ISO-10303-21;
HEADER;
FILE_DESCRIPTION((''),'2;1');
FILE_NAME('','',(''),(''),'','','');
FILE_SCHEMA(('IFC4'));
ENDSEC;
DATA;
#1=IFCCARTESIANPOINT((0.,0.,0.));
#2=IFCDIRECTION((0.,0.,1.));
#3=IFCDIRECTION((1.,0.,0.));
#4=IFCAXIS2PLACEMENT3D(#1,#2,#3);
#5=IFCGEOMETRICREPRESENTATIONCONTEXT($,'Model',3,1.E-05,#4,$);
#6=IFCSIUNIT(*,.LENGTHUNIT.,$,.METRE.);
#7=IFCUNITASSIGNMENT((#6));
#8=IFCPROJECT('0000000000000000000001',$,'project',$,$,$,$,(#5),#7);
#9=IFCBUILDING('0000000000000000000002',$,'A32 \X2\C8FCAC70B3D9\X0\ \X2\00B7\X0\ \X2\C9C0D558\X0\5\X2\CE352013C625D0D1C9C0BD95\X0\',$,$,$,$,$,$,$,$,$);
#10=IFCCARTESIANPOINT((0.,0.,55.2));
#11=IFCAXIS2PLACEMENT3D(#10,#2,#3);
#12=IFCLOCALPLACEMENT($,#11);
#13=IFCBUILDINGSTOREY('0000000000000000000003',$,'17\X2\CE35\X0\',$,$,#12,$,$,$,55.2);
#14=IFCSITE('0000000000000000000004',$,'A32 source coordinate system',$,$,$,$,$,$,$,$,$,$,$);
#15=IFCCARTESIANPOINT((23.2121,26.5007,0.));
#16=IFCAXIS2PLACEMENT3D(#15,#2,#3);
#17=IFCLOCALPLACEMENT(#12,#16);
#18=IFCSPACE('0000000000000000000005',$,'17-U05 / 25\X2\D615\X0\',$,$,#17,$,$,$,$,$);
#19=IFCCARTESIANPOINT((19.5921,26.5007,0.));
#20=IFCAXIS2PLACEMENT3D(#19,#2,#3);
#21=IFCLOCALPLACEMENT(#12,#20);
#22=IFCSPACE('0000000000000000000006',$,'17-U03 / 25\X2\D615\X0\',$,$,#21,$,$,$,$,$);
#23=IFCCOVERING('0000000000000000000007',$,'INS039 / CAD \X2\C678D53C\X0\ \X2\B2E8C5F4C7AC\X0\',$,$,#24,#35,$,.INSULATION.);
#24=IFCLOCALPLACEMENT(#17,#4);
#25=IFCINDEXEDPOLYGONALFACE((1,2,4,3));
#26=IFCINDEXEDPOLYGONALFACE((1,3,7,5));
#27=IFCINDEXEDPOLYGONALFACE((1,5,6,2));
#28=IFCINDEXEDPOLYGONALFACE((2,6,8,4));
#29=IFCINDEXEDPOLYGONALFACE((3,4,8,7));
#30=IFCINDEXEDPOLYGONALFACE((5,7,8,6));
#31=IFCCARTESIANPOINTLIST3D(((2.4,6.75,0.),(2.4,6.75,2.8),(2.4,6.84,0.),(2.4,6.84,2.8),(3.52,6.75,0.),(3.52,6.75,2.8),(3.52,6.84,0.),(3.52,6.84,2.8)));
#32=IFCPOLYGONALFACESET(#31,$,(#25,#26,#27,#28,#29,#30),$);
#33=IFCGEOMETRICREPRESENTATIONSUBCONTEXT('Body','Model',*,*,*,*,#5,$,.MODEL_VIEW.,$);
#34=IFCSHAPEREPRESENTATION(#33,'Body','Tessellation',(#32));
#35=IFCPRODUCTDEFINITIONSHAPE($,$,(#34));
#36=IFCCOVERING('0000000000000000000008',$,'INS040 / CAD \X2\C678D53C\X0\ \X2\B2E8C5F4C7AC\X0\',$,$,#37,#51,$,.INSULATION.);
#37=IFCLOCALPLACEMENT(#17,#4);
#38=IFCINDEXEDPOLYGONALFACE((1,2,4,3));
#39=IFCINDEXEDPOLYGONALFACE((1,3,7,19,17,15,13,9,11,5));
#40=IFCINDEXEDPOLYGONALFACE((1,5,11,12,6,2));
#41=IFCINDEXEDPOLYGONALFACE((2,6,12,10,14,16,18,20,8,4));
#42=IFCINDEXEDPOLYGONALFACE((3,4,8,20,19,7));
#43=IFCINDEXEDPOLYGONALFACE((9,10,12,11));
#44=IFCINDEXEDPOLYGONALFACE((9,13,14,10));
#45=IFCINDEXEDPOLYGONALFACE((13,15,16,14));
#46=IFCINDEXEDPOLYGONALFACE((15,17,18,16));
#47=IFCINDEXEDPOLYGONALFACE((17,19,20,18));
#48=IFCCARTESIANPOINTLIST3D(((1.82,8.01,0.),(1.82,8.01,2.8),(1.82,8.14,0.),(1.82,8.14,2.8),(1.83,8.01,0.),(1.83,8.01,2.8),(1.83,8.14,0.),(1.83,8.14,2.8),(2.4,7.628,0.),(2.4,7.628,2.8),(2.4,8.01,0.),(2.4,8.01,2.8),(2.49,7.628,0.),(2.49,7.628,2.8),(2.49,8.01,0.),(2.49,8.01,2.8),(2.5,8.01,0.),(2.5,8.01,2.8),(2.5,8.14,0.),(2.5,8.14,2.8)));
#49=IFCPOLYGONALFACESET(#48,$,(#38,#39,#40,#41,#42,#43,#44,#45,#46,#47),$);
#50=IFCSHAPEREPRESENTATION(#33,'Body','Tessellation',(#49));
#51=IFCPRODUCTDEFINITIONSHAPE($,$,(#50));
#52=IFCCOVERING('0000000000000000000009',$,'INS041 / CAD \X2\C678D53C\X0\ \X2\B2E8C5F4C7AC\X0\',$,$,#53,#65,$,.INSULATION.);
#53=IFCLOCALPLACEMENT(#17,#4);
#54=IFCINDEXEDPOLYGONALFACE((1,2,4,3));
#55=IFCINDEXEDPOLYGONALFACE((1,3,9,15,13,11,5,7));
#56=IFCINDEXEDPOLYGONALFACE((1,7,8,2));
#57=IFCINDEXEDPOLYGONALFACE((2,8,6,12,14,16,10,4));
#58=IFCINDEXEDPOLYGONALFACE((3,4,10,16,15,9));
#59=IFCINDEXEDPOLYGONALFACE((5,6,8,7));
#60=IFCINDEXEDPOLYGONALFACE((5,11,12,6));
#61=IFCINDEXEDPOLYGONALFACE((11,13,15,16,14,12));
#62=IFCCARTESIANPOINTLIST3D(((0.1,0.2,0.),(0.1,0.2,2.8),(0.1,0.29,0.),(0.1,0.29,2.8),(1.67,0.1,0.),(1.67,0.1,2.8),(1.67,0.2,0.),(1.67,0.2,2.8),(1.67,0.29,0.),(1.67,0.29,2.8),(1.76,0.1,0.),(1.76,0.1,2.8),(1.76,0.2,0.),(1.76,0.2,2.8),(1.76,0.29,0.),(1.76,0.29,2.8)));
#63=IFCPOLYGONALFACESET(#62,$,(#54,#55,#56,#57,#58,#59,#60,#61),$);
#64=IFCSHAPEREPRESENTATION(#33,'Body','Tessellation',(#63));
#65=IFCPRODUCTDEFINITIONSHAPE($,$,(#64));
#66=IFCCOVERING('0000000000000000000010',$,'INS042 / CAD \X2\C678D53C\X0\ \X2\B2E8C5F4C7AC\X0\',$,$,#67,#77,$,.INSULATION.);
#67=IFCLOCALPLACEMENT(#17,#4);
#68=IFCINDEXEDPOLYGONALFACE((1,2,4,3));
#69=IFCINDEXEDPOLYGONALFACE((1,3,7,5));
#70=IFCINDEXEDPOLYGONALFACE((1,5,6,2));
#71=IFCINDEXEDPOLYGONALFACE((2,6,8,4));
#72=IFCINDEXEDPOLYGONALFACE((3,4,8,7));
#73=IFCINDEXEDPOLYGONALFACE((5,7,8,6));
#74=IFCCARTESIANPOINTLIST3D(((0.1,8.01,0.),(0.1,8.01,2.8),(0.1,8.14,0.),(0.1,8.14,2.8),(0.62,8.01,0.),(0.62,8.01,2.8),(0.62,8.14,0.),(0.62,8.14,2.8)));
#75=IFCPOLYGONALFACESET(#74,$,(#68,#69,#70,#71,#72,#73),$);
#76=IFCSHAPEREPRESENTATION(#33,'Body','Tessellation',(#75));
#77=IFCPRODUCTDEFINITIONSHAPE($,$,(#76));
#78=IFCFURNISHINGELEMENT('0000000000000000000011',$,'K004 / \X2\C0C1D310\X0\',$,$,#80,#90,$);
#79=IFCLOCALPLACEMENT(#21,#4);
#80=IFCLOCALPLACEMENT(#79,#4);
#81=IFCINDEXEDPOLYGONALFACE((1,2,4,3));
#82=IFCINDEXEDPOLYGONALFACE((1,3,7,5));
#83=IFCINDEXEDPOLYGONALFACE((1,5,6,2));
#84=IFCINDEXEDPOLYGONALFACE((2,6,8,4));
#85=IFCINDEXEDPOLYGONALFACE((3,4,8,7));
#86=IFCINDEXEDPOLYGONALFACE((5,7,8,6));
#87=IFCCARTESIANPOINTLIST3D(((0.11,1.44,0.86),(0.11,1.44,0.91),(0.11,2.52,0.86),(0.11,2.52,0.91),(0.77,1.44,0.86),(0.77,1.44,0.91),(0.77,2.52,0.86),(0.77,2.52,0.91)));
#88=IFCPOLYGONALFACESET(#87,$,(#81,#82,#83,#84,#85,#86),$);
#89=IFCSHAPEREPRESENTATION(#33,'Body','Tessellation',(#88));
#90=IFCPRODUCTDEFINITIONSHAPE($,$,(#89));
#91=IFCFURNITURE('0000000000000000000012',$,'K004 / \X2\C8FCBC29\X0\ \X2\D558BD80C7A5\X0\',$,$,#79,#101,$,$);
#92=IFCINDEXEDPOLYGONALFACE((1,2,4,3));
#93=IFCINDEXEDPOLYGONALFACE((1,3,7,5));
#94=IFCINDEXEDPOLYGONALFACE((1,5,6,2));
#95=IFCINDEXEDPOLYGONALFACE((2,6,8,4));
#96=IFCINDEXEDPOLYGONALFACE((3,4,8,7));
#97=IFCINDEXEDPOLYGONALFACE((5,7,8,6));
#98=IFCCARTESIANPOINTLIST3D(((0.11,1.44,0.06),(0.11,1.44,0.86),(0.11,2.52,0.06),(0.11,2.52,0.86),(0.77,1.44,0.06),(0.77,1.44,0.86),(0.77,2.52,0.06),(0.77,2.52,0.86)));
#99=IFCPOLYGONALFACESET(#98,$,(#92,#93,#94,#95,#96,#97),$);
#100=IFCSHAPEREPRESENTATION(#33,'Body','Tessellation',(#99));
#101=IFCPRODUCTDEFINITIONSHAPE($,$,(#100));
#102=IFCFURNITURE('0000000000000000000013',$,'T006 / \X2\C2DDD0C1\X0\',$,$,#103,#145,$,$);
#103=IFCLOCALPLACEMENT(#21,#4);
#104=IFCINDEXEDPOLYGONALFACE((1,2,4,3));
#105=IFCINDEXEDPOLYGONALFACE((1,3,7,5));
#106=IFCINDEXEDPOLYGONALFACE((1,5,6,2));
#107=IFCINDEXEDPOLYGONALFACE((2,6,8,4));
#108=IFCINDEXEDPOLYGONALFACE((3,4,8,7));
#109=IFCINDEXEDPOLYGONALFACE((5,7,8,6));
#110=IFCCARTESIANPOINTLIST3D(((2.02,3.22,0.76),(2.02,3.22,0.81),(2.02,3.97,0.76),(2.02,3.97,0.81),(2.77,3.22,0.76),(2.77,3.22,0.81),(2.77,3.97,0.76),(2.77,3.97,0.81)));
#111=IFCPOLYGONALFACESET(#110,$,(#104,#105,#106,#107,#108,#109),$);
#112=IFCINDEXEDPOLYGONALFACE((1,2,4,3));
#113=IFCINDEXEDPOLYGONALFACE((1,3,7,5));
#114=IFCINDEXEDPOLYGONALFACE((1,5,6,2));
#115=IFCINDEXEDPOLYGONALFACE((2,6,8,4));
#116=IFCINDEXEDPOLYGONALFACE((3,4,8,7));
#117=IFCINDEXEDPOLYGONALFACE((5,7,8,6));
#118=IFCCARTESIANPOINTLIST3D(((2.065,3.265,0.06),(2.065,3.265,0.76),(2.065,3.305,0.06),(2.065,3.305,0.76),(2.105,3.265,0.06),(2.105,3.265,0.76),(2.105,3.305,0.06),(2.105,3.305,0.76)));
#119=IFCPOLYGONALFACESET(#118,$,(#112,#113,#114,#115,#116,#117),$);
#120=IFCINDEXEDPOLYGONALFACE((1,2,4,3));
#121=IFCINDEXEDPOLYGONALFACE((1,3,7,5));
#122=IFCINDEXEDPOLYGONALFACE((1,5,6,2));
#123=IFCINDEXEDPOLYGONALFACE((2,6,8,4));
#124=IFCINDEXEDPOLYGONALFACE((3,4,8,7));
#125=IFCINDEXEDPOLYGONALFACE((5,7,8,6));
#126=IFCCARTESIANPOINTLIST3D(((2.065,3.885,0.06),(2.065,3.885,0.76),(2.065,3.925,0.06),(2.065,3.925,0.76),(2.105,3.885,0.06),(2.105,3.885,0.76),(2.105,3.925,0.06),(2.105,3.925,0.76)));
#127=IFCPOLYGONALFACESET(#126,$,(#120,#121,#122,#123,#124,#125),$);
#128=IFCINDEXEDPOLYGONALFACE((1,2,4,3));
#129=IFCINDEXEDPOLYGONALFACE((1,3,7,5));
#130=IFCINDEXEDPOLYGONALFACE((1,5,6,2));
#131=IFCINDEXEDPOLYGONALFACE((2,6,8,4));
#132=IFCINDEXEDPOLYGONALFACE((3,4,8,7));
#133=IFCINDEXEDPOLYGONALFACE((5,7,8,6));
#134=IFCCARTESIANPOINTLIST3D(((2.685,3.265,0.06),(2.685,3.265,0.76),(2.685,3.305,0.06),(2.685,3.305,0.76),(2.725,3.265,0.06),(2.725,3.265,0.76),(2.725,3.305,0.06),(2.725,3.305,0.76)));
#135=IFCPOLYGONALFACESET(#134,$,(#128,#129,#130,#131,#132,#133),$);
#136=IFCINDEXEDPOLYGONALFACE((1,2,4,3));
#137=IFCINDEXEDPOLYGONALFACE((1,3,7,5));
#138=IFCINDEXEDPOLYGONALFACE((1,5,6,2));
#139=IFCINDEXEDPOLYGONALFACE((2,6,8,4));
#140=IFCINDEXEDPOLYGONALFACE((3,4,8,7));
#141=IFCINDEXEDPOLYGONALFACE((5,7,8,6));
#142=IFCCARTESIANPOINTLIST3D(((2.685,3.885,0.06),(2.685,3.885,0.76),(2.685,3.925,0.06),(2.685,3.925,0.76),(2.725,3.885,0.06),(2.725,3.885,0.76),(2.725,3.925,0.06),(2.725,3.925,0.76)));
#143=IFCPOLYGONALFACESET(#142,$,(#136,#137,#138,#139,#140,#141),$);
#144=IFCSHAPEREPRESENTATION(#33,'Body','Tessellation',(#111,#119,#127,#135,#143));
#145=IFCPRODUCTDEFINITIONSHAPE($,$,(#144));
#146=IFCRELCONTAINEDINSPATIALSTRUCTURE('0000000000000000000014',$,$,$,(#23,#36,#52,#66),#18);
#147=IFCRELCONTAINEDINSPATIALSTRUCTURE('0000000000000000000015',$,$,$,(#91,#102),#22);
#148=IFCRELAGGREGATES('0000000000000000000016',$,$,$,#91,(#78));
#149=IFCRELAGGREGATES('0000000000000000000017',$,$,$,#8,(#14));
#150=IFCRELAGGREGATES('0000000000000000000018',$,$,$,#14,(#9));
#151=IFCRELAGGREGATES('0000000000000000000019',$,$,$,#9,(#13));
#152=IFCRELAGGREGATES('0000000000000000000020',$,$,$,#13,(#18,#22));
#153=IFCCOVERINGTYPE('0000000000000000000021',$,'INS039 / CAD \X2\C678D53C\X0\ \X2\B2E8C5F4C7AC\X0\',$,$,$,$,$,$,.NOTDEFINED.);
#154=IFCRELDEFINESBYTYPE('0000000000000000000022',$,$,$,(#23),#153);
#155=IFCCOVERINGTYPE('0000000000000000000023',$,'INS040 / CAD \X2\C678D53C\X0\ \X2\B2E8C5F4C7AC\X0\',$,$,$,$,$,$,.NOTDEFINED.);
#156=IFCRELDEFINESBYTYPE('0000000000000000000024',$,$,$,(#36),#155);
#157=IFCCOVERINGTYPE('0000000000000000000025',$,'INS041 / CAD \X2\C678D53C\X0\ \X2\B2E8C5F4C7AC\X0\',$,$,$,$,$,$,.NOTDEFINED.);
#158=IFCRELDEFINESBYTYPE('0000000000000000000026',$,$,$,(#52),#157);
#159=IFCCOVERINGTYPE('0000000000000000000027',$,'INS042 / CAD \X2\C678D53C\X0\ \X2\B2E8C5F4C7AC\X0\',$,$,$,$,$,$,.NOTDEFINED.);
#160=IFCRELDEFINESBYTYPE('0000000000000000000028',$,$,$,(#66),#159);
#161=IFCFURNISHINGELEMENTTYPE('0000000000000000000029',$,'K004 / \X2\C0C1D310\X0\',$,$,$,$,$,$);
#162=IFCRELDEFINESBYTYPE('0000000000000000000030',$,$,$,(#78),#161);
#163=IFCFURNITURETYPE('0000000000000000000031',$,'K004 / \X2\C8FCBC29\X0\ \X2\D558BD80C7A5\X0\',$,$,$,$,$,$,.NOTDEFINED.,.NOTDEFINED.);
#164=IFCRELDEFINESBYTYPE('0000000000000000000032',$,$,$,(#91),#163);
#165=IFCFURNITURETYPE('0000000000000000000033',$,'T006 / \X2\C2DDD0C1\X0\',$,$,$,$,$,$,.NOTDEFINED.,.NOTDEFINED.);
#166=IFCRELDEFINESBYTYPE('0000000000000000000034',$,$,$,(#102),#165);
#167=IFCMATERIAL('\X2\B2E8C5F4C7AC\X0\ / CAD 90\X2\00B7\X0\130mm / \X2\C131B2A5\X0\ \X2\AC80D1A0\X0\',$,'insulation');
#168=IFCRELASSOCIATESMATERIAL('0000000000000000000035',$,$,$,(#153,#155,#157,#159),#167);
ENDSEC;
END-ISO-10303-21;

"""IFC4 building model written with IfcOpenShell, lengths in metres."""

from ifc_helpers import new_model, si_unit, frame, origin, origin_with_axes, place, context, subcontext, project, spatial, polyline, outline, extrude, source, transform, mapped, material, type_object, type_shapes, element, aggregate, save


model = new_model("IFC4")

# Units and contexts
model_context = context("Model", 3, precision=1e-05, world=origin_with_axes())
body_context = subcontext(model_context, "Body", "Model", "MODEL_VIEW")
ifc_project = project(units=[si_unit("LENGTHUNIT", "METRE")], contexts=[model_context])

# Site, building, storey, space
storey_placement = place(None, frame((0.0, 0.0, 55.2), z_axis=(0.0, 0.0, 1.0), x_axis=(1.0, 0.0, 0.0)))
space_1_placement = place(storey_placement, frame((23.2121, 26.5007, 0.0), z_axis=(0.0, 0.0, 1.0), x_axis=(1.0, 0.0, 0.0)))
site = spatial("IfcSite", under=ifc_project, Name="A32 source coordinate system")
building = spatial("IfcBuilding", under=site, Name="A32 주거동 · 지하5층–옥탑지붕")
storey = spatial("IfcBuildingStorey", under=building, at=storey_placement, Name="17층", Elevation=55.2)
space_1 = spatial("IfcSpace", under=storey, at=space_1_placement, Name="17-U05 / 25형")

# Shared definitions
space_2_placement = place(storey_placement, frame((19.5921, 26.5007, 0.0), z_axis=(0.0, 0.0, 1.0), x_axis=(1.0, 0.0, 0.0)))
space_2 = spatial("IfcSpace", under=storey, at=space_2_placement, Name="17-U03 / 25형")

# Coverings
ifc_material = material(Name="단열재 / CAD 90·130mm / 성능 검토", Category="insulation")
covering_type_1 = type_object("IfcCoveringType", Name="INS039 / CAD 외피 단열재", PredefinedType="NOTDEFINED", material=ifc_material)
shared_shape_1 = source(origin(), body_context, "Body", "SweptSolid", [
    extrude(outline(polyline([(2.4, 6.75), (2.4, 6.84), (3.52, 6.84), (3.52, 6.75), (2.4, 6.75)])), origin(), (0.0, 0.0, 1.0), 2.8),
])
type_shapes(covering_type_1, [shared_shape_1])
covering_1_placement = place(space_1_placement, origin_with_axes())
element("IfcCovering", 1, at=covering_1_placement, inside=space_1, type_object=covering_type_1, Name="INS039 / CAD 외피 단열재", PredefinedType="INSULATION", context=body_context, shape_type="MappedRepresentation", body=[
    mapped(shared_shape_1, transform((0.0, 0.0, 0.0), scale=1.0)),
])
covering_type_2 = type_object("IfcCoveringType", Name="INS040 / CAD 외피 단열재", PredefinedType="NOTDEFINED", material=ifc_material)
shared_shape_2 = source(origin(), body_context, "Body", "SweptSolid", [
    extrude(outline(polyline([(2.4, 7.628), (2.4, 8.01), (1.83, 8.01), (1.82, 8.01), (1.82, 8.14), (1.83, 8.14), (2.5, 8.14), (2.5, 8.01), (2.49, 8.01), (2.49, 7.628), (2.4, 7.628)])), origin(), (0.0, 0.0, 1.0), 2.8),
])
type_shapes(covering_type_2, [shared_shape_2])
covering_2_placement = place(space_1_placement, origin_with_axes())
element("IfcCovering", 2, at=covering_2_placement, inside=space_1, type_object=covering_type_2, Name="INS040 / CAD 외피 단열재", PredefinedType="INSULATION", context=body_context, shape_type="MappedRepresentation", body=[
    mapped(shared_shape_2, transform((0.0, 0.0, 0.0), scale=1.0)),
])
covering_type_3 = type_object("IfcCoveringType", Name="INS041 / CAD 외피 단열재", PredefinedType="NOTDEFINED", material=ifc_material)
shared_shape_3 = source(origin(), body_context, "Body", "SweptSolid", [
    extrude(outline(polyline([(1.67, 0.2), (0.1, 0.2), (0.1, 0.29), (1.67, 0.29), (1.76, 0.29), (1.76, 0.2), (1.76, 0.1), (1.67, 0.1), (1.67, 0.2)])), origin(), (0.0, 0.0, 1.0), 2.8),
])
type_shapes(covering_type_3, [shared_shape_3])
covering_3_placement = place(space_1_placement, origin_with_axes())
element("IfcCovering", 3, at=covering_3_placement, inside=space_1, type_object=covering_type_3, Name="INS041 / CAD 외피 단열재", PredefinedType="INSULATION", context=body_context, shape_type="MappedRepresentation", body=[
    mapped(shared_shape_3, transform((0.0, 0.0, 0.0), scale=1.0)),
])
covering_type_4 = type_object("IfcCoveringType", Name="INS042 / CAD 외피 단열재", PredefinedType="NOTDEFINED", material=ifc_material)
shared_shape_4 = source(origin(), body_context, "Body", "SweptSolid", [
    extrude(outline(polyline([(0.62, 8.14), (0.62, 8.01), (0.1, 8.01), (0.1, 8.14), (0.62, 8.14)])), origin(), (0.0, 0.0, 1.0), 2.8),
])
type_shapes(covering_type_4, [shared_shape_4])
covering_4_placement = place(space_1_placement, origin_with_axes())
element("IfcCovering", 4, at=covering_4_placement, inside=space_1, type_object=covering_type_4, Name="INS042 / CAD 외피 단열재", PredefinedType="INSULATION", context=body_context, shape_type="MappedRepresentation", body=[
    mapped(shared_shape_4, transform((0.0, 0.0, 0.0), scale=1.0)),
])

# Furnishing element
furnishing_element_type_1 = type_object("IfcFurnishingElementType", Name="K004 / 상판")
shared_shape_5 = source(origin(), body_context, "Body", "SweptSolid", [
    extrude(outline(polyline([(0.77, 2.52), (0.77, 1.44), (0.11, 1.44), (0.11, 2.52), (0.77, 2.52)])), frame((0.0, 0.0, 0.86)), (0.0, 0.0, 1.0), 0.05),
])
type_shapes(furnishing_element_type_1, [shared_shape_5])
furniture_1_placement = place(space_2_placement, origin_with_axes())
furnishing_1_placement = place(furniture_1_placement, origin_with_axes())
furnishing_1 = element("IfcFurnishingElement", 5, at=furnishing_1_placement, type_object=furnishing_element_type_1, Name="K004 / 상판", context=body_context, shape_type="MappedRepresentation", body=[
    mapped(shared_shape_5, transform((0.0, 0.0, 0.0), scale=1.0)),
])

# Furniture
furniture_type_1 = type_object("IfcFurnitureType", Name="K004 / 주방 하부장", AssemblyPlace="NOTDEFINED", PredefinedType="NOTDEFINED")
shared_shape_6 = source(origin(), body_context, "Body", "SweptSolid", [
    extrude(outline(polyline([(0.11, 2.52), (0.77, 2.52), (0.77, 1.44), (0.11, 1.44), (0.11, 2.52)])), frame((0.0, 0.0, 0.06)), (0.0, 0.0, 1.0), 0.8),
])
type_shapes(furniture_type_1, [shared_shape_6])
furniture_1 = element("IfcFurniture", 6, at=furniture_1_placement, inside=space_2, type_object=furniture_type_1, Name="K004 / 주방 하부장", context=body_context, shape_type="MappedRepresentation", body=[
    mapped(shared_shape_6, transform((0.0, 0.0, 0.0), scale=1.0)),
])
aggregate(furniture_1, [furnishing_1])
furniture_type_2 = type_object("IfcFurnitureType", Name="T006 / 식탁", AssemblyPlace="NOTDEFINED", PredefinedType="NOTDEFINED")
shared_shape_7 = source(origin(), body_context, "Body", "SweptSolid", [
    extrude(outline(polyline([(2.77, 3.22), (2.02, 3.22), (2.02, 3.97), (2.77, 3.97), (2.77, 3.22)])), frame((0.0, 0.0, 0.76)), (0.0, 0.0, 1.0), 0.05),
    extrude(outline(polyline([(2.065, 3.265), (2.065, 3.305), (2.105, 3.305), (2.105, 3.265), (2.065, 3.265)])), frame((0.0, 0.0, 0.06)), (0.0, 0.0, 1.0), 0.7),
    extrude(outline(polyline([(2.065, 3.885), (2.065, 3.925), (2.105, 3.925), (2.105, 3.885), (2.065, 3.885)])), frame((0.0, 0.0, 0.06)), (0.0, 0.0, 1.0), 0.7),
    extrude(outline(polyline([(2.685, 3.265), (2.685, 3.305), (2.725, 3.305), (2.725, 3.265), (2.685, 3.265)])), frame((0.0, 0.0, 0.06)), (0.0, 0.0, 1.0), 0.7),
    extrude(outline(polyline([(2.685, 3.885), (2.685, 3.925), (2.725, 3.925), (2.725, 3.885), (2.685, 3.885)])), frame((0.0, 0.0, 0.06)), (0.0, 0.0, 1.0), 0.7),
])
type_shapes(furniture_type_2, [shared_shape_7])
furniture_2_placement = place(space_2_placement, origin_with_axes())
element("IfcFurniture", 7, at=furniture_2_placement, inside=space_2, type_object=furniture_type_2, Name="T006 / 식탁", context=body_context, shape_type="MappedRepresentation", body=[
    mapped(shared_shape_7, transform((0.0, 0.0, 0.0), scale=1.0)),
])

save(model, "model.ifc")
